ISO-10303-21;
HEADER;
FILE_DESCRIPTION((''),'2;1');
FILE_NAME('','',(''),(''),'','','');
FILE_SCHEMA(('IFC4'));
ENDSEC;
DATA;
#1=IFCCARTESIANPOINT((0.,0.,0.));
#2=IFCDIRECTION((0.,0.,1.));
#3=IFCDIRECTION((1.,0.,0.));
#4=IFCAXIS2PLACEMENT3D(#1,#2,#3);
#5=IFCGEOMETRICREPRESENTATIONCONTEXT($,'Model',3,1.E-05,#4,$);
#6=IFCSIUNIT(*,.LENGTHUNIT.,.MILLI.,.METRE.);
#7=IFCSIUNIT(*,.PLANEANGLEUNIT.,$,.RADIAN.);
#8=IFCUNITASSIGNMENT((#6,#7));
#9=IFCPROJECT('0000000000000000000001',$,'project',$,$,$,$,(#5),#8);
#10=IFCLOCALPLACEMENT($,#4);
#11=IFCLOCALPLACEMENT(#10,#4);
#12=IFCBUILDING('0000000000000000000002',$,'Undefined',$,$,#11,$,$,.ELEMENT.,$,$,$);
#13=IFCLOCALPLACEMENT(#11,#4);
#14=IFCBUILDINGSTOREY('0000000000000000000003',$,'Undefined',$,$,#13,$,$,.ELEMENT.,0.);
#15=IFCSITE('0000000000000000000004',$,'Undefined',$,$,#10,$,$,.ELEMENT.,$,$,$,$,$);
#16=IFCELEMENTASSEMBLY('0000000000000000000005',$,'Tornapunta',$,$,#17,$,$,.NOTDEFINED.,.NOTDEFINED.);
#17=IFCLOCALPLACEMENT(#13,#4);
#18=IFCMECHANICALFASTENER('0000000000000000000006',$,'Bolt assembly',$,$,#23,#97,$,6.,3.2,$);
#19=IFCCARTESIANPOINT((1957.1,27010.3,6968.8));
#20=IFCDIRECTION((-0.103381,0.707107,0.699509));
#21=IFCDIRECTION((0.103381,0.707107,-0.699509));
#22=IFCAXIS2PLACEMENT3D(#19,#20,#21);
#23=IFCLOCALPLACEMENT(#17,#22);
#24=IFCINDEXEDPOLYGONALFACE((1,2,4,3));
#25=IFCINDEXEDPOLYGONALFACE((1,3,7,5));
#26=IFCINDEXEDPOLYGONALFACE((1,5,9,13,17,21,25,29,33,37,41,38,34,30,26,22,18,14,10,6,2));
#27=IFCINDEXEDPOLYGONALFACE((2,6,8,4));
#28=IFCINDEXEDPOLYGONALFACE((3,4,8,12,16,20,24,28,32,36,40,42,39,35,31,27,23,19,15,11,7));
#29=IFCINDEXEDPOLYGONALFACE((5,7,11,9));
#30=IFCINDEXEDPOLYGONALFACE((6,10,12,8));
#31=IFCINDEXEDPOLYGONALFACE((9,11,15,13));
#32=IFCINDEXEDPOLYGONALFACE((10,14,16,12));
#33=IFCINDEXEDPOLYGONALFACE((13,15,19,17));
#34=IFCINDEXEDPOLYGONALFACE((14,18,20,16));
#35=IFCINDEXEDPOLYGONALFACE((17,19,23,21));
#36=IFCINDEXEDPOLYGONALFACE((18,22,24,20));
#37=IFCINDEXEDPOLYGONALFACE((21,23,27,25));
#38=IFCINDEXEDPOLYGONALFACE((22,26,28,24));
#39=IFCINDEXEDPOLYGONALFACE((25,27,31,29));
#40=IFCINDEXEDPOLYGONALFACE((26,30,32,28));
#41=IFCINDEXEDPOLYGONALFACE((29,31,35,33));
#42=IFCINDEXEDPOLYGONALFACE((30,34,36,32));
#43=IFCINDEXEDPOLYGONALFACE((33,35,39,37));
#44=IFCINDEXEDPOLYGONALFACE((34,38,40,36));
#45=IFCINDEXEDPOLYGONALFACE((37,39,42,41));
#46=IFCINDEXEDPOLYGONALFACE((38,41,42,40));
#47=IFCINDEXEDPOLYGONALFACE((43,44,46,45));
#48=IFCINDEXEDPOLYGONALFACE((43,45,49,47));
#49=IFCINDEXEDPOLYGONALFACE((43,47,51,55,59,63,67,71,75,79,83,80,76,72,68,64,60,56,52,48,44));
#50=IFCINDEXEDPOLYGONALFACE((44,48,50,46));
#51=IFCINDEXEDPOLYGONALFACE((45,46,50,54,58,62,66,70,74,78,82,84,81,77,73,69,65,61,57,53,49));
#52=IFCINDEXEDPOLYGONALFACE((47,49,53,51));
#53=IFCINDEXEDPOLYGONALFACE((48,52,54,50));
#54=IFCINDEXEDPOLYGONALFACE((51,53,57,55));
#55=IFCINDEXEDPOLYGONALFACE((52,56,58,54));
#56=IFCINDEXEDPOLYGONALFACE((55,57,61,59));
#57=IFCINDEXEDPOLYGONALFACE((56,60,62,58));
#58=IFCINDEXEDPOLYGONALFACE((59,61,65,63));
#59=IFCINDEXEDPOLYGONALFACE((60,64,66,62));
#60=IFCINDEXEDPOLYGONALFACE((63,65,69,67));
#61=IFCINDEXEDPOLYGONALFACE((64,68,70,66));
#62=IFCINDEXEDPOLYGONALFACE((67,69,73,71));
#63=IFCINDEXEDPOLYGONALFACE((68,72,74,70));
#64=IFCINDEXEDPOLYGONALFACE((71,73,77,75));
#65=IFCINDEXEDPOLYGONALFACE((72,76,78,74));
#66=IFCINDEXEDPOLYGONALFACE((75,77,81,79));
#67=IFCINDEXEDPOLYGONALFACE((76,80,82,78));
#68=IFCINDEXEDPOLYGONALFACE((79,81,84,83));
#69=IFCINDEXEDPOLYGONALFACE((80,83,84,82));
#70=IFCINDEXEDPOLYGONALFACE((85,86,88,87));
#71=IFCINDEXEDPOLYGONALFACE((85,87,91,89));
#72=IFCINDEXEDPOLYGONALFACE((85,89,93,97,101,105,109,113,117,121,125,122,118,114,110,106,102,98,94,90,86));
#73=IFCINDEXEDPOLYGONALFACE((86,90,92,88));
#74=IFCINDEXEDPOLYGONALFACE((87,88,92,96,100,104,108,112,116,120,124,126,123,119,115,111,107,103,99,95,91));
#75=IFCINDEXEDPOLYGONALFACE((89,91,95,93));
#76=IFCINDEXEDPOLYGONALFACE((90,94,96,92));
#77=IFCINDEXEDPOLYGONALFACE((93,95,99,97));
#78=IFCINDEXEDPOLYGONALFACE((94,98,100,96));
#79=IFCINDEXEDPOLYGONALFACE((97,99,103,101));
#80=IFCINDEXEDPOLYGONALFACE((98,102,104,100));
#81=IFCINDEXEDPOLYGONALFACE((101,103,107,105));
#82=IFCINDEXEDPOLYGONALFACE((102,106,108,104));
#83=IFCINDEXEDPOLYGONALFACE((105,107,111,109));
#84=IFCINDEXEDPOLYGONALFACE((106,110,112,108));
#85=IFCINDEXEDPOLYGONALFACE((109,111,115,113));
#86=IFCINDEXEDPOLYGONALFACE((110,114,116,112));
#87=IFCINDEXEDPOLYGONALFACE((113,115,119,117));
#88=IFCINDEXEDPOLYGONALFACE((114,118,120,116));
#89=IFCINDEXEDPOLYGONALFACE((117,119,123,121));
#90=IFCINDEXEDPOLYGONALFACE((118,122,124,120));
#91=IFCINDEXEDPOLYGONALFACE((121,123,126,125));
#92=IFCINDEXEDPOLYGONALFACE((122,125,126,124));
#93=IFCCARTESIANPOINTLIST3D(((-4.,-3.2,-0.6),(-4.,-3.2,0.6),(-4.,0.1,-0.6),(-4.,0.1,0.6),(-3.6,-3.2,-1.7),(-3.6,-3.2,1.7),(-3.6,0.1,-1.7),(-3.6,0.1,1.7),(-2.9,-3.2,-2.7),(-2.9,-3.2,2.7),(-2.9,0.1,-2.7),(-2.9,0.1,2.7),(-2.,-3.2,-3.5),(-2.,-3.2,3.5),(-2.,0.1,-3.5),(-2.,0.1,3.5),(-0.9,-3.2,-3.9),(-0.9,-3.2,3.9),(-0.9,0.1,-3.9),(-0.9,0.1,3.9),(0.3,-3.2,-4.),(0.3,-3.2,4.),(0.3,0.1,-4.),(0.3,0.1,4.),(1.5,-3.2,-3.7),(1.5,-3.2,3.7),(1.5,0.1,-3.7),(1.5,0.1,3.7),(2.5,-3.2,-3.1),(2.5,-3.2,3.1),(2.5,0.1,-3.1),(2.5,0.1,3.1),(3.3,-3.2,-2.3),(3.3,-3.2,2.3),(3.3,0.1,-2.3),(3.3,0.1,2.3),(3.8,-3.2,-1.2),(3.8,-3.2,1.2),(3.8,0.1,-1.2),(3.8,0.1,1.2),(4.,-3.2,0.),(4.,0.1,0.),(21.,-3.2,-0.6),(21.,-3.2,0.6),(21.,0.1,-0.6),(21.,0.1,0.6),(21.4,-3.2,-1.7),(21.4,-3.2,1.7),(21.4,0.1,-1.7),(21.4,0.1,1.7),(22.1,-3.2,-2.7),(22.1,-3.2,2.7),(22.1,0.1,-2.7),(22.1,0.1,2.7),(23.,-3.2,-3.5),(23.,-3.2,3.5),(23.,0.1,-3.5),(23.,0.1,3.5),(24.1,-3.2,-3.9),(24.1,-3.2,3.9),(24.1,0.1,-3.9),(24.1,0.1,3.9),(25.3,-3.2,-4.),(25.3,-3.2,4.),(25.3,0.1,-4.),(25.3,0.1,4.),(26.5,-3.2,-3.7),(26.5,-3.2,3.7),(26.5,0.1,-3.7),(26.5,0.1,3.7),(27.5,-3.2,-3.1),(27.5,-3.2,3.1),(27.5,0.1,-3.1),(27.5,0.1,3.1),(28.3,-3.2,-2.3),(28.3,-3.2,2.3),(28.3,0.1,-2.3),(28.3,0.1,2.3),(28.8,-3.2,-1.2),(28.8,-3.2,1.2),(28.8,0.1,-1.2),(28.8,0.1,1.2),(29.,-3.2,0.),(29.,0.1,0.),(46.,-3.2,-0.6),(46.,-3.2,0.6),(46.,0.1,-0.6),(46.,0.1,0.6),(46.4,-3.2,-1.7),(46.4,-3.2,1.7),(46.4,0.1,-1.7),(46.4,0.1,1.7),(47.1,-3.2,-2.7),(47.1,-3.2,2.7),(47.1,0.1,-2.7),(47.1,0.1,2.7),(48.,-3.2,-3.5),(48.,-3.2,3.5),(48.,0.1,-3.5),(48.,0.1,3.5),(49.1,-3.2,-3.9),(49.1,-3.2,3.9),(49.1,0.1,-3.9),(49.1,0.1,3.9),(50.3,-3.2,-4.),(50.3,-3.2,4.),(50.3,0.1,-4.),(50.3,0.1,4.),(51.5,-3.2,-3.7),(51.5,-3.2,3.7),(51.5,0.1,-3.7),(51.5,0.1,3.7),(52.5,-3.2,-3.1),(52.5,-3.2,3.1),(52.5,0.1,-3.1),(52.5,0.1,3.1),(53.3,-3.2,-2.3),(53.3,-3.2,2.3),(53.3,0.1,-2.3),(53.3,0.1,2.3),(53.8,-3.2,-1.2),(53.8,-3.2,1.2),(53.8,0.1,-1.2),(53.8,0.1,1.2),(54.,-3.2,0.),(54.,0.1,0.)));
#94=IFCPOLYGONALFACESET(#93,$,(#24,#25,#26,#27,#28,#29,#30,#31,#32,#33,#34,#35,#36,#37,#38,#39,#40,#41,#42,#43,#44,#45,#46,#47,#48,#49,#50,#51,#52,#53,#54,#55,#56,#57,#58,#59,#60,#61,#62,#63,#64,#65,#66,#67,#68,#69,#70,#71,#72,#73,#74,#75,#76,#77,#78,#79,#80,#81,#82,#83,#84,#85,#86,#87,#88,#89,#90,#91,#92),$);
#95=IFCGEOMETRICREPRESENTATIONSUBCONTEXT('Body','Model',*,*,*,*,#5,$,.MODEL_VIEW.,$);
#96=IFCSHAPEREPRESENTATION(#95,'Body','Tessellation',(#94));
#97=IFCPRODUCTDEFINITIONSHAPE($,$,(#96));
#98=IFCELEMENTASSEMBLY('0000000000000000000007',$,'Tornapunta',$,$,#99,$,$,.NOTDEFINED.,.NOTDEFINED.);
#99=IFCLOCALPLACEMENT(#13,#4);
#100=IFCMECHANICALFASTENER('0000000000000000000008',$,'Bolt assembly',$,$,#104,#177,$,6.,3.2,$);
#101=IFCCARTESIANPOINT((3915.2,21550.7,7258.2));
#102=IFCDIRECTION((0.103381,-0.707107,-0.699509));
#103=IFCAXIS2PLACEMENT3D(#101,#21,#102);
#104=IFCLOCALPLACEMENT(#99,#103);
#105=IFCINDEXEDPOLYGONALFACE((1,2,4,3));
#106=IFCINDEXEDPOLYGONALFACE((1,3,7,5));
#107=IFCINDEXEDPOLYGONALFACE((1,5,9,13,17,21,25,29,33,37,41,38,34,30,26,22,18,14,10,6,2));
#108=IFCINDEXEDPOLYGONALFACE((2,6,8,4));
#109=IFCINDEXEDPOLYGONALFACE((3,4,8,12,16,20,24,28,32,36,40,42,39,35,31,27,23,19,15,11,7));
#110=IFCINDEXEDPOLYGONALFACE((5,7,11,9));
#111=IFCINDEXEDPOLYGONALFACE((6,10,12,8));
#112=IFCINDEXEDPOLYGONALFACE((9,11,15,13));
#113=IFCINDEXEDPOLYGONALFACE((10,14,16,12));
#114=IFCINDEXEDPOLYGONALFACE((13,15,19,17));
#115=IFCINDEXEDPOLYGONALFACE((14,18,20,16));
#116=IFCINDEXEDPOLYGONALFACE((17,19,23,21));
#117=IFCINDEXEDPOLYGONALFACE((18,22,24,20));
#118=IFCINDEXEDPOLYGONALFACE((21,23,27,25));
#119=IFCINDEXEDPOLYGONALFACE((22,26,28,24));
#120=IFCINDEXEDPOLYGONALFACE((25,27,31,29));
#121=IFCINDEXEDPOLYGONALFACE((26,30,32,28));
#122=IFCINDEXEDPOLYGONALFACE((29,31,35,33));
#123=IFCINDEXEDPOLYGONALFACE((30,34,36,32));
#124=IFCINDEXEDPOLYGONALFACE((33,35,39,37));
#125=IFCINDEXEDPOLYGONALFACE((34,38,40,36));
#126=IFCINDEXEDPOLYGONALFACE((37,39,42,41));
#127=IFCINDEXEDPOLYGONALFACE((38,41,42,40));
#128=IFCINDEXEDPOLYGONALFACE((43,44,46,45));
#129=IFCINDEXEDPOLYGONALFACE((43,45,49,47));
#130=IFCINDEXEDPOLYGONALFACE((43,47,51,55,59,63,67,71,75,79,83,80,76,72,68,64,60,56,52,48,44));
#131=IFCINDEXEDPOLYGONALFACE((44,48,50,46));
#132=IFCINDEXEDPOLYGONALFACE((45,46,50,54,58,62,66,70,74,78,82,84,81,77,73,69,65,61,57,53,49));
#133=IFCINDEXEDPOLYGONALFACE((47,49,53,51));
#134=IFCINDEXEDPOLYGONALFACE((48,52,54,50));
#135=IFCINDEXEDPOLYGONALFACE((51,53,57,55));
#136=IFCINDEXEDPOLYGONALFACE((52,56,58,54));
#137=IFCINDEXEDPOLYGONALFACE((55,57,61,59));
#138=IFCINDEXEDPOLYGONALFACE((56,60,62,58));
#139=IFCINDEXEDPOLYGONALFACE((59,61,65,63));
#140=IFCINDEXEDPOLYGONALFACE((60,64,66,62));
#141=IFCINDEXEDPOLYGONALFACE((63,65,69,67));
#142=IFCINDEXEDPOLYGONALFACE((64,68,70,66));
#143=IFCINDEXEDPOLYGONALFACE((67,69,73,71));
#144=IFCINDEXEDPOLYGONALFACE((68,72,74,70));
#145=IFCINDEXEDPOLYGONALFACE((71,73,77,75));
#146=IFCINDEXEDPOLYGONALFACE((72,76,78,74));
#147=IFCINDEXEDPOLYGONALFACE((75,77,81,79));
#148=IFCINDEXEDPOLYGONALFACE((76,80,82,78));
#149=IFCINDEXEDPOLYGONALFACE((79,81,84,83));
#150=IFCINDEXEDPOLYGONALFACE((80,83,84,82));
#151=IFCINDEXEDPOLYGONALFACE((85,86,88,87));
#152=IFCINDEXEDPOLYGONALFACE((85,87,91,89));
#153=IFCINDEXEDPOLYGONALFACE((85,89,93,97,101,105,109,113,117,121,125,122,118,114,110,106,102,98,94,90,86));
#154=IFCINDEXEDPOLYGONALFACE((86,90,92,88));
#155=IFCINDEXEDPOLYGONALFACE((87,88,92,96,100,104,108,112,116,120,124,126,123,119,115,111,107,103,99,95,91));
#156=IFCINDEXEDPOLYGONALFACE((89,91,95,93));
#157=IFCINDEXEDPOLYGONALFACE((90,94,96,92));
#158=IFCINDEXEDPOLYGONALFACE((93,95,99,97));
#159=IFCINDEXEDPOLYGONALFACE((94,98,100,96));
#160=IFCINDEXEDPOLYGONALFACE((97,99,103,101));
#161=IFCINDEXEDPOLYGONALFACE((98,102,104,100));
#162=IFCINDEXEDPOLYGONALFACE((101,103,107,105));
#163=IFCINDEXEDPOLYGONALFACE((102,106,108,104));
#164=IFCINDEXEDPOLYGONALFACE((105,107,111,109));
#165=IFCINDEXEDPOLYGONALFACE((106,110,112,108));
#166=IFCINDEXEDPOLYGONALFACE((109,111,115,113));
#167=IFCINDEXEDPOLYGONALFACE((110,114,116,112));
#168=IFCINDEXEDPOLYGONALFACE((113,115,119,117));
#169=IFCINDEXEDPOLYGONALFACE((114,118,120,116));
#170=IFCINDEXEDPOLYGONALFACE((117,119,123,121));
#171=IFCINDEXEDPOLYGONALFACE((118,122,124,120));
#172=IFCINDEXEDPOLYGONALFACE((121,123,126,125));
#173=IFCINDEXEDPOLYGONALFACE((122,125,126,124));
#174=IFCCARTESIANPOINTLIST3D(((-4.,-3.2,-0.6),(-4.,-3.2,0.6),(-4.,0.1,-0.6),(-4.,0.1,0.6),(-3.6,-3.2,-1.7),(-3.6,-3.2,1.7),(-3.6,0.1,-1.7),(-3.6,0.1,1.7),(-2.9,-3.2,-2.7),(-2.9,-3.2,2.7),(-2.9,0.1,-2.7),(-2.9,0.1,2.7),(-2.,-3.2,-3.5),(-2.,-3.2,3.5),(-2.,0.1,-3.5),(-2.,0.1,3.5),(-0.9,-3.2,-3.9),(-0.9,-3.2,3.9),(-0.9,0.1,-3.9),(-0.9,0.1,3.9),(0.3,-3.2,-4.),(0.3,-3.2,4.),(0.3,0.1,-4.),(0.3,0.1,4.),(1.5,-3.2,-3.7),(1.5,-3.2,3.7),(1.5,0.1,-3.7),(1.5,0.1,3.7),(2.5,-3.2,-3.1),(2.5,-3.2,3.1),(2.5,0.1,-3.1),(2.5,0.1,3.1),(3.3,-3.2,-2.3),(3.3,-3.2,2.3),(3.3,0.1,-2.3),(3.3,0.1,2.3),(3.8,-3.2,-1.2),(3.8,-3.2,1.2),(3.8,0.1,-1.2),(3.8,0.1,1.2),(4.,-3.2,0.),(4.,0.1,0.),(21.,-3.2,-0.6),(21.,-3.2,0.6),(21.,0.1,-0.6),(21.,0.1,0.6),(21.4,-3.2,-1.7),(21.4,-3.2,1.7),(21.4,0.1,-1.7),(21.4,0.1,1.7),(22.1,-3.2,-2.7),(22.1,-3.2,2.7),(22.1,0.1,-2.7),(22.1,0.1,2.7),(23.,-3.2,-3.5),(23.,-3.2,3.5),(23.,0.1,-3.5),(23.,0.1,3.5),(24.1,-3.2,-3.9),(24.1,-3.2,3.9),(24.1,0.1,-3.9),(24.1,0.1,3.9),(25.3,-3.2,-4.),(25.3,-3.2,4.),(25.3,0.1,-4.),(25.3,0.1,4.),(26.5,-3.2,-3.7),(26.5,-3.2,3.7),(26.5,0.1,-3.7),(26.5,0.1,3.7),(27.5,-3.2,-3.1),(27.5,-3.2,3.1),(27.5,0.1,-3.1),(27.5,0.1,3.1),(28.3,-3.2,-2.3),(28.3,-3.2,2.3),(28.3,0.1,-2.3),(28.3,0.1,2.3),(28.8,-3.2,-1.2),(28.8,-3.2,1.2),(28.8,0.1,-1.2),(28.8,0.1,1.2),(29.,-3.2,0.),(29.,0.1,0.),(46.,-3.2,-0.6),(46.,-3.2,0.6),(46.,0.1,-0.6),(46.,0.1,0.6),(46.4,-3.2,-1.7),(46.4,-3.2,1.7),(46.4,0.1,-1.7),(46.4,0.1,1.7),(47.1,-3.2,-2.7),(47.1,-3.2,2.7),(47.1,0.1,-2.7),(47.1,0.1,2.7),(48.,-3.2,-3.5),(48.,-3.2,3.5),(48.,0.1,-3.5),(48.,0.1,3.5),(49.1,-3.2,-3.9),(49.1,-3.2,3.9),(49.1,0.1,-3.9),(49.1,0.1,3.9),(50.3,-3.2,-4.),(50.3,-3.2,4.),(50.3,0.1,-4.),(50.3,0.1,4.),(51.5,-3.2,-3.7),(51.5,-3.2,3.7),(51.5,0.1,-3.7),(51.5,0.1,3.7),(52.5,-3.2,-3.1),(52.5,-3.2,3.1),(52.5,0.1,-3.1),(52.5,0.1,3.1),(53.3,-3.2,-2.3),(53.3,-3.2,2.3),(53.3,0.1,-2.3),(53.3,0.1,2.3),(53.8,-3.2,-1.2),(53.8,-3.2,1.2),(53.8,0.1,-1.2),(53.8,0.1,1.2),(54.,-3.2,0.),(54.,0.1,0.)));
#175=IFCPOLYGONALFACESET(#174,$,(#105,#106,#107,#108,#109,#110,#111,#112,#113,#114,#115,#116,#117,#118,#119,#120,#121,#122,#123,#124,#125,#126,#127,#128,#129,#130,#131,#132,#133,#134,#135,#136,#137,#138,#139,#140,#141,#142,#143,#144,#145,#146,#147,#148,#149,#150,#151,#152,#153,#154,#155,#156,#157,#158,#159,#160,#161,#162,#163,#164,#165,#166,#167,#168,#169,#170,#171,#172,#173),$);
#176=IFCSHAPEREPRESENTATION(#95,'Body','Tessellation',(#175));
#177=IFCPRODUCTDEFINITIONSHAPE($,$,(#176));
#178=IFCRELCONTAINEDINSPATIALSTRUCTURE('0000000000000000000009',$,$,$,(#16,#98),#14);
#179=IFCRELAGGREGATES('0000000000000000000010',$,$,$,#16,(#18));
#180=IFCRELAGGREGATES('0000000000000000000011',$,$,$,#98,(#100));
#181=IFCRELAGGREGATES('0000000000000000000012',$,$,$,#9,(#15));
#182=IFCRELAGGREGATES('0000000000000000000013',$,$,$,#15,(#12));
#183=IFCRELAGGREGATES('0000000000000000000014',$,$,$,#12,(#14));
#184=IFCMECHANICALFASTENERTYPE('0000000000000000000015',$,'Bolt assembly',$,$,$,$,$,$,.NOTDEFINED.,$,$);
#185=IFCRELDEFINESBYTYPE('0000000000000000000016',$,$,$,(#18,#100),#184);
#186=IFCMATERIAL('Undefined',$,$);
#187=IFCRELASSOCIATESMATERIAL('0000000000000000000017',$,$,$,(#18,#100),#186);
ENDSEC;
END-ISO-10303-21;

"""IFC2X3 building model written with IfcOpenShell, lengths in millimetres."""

from ifc_helpers import new_model, si_unit, frame, origin_with_axes, origin_2d_with_axis, place, context, subcontext, project, spatial, circle, extrude, source, transform, mapped, material, type_object, element, aggregate, save


model = new_model("IFC2X3")

# Units and contexts
model_context = context("Model", 3, precision=1e-05, world=origin_with_axes())
body_context = subcontext(model_context, "Body", "Model", "MODEL_VIEW")
ifc_project = project(units=[si_unit("LENGTHUNIT", "METRE", prefix="MILLI"), si_unit("PLANEANGLEUNIT", "RADIAN")], contexts=[model_context])

# Site, building, storey
site_placement = place(None, origin_with_axes())
site = spatial("IfcSite", under=ifc_project, at=site_placement, Name="Undefined", CompositionType="ELEMENT")
building_placement = place(site_placement, origin_with_axes())
building = spatial("IfcBuilding", under=site, at=building_placement, Name="Undefined", CompositionType="ELEMENT")
storey_placement = place(building_placement, origin_with_axes())
storey = spatial("IfcBuildingStorey", under=building, at=storey_placement, Name="Undefined", CompositionType="ELEMENT", Elevation=0.0)

# Shared definitions
ifc_material_1 = material(Name="Undefined")
mechanical_fastener_type = type_object("IfcMechanicalFastenerType", Name="Bolt assembly")

# Element assemblies, mechanical fasteners
shared_shape_1 = source(origin_with_axes(), body_context, "Body", "SweptSolid", [
    extrude(circle(Radius=4.0, at=origin_2d_with_axis()), frame((0.0, -3.2, 0.0), z_axis=(0.0, 1.0, 0.0), x_axis=(1.0, 0.0, 0.0)), (0.0, 0.0, 1.0), 3.3),
])
assembly_1_placement = place(storey_placement, origin_with_axes())
assembly_1 = element("IfcElementAssembly", 1, at=assembly_1_placement, inside=storey, Name="Tornapunta", AssemblyPlace="NOTDEFINED", PredefinedType="NOTDEFINED")
mechanical_fastener_1_placement = place(assembly_1_placement, frame((1957.1, 27010.3, 6968.8), z_axis=(-0.103381, 0.707107, 0.699509), x_axis=(0.103381, 0.707107, -0.699509)))
mechanical_fastener_1 = element("IfcMechanicalFastener", 2, at=mechanical_fastener_1_placement, type_object=mechanical_fastener_type, material=ifc_material_1, Name="Bolt assembly", NominalDiameter=6.0, NominalLength=3.2, context=body_context, shape_type="MappedRepresentation", body=[
    mapped(shared_shape_1, transform((0.0, 0.0, 0.0))),
    mapped(shared_shape_1, transform((25.0, 0.0, 0.0))),
    mapped(shared_shape_1, transform((50.0, 0.0, 0.0))),
])
aggregate(assembly_1, [mechanical_fastener_1])
assembly_2_placement = place(storey_placement, origin_with_axes())
assembly_2 = element("IfcElementAssembly", 3, at=assembly_2_placement, inside=storey, Name="Tornapunta", AssemblyPlace="NOTDEFINED", PredefinedType="NOTDEFINED")
mechanical_fastener_2_placement = place(assembly_2_placement, frame((3915.2, 21550.7, 7258.2), z_axis=(0.103381, 0.707107, -0.699509), x_axis=(0.103381, -0.707107, -0.699509)))
mechanical_fastener_2 = element("IfcMechanicalFastener", 4, at=mechanical_fastener_2_placement, type_object=mechanical_fastener_type, material=ifc_material_1, Name="Bolt assembly", NominalDiameter=6.0, NominalLength=3.2, context=body_context, shape_type="MappedRepresentation", body=[
    mapped(shared_shape_1, transform((0.0, 0.0, 0.0))),
    mapped(shared_shape_1, transform((25.0, 0.0, 0.0))),
    mapped(shared_shape_1, transform((50.0, 0.0, 0.0))),
])
aggregate(assembly_2, [mechanical_fastener_2])

save(model, "model.ifc")
